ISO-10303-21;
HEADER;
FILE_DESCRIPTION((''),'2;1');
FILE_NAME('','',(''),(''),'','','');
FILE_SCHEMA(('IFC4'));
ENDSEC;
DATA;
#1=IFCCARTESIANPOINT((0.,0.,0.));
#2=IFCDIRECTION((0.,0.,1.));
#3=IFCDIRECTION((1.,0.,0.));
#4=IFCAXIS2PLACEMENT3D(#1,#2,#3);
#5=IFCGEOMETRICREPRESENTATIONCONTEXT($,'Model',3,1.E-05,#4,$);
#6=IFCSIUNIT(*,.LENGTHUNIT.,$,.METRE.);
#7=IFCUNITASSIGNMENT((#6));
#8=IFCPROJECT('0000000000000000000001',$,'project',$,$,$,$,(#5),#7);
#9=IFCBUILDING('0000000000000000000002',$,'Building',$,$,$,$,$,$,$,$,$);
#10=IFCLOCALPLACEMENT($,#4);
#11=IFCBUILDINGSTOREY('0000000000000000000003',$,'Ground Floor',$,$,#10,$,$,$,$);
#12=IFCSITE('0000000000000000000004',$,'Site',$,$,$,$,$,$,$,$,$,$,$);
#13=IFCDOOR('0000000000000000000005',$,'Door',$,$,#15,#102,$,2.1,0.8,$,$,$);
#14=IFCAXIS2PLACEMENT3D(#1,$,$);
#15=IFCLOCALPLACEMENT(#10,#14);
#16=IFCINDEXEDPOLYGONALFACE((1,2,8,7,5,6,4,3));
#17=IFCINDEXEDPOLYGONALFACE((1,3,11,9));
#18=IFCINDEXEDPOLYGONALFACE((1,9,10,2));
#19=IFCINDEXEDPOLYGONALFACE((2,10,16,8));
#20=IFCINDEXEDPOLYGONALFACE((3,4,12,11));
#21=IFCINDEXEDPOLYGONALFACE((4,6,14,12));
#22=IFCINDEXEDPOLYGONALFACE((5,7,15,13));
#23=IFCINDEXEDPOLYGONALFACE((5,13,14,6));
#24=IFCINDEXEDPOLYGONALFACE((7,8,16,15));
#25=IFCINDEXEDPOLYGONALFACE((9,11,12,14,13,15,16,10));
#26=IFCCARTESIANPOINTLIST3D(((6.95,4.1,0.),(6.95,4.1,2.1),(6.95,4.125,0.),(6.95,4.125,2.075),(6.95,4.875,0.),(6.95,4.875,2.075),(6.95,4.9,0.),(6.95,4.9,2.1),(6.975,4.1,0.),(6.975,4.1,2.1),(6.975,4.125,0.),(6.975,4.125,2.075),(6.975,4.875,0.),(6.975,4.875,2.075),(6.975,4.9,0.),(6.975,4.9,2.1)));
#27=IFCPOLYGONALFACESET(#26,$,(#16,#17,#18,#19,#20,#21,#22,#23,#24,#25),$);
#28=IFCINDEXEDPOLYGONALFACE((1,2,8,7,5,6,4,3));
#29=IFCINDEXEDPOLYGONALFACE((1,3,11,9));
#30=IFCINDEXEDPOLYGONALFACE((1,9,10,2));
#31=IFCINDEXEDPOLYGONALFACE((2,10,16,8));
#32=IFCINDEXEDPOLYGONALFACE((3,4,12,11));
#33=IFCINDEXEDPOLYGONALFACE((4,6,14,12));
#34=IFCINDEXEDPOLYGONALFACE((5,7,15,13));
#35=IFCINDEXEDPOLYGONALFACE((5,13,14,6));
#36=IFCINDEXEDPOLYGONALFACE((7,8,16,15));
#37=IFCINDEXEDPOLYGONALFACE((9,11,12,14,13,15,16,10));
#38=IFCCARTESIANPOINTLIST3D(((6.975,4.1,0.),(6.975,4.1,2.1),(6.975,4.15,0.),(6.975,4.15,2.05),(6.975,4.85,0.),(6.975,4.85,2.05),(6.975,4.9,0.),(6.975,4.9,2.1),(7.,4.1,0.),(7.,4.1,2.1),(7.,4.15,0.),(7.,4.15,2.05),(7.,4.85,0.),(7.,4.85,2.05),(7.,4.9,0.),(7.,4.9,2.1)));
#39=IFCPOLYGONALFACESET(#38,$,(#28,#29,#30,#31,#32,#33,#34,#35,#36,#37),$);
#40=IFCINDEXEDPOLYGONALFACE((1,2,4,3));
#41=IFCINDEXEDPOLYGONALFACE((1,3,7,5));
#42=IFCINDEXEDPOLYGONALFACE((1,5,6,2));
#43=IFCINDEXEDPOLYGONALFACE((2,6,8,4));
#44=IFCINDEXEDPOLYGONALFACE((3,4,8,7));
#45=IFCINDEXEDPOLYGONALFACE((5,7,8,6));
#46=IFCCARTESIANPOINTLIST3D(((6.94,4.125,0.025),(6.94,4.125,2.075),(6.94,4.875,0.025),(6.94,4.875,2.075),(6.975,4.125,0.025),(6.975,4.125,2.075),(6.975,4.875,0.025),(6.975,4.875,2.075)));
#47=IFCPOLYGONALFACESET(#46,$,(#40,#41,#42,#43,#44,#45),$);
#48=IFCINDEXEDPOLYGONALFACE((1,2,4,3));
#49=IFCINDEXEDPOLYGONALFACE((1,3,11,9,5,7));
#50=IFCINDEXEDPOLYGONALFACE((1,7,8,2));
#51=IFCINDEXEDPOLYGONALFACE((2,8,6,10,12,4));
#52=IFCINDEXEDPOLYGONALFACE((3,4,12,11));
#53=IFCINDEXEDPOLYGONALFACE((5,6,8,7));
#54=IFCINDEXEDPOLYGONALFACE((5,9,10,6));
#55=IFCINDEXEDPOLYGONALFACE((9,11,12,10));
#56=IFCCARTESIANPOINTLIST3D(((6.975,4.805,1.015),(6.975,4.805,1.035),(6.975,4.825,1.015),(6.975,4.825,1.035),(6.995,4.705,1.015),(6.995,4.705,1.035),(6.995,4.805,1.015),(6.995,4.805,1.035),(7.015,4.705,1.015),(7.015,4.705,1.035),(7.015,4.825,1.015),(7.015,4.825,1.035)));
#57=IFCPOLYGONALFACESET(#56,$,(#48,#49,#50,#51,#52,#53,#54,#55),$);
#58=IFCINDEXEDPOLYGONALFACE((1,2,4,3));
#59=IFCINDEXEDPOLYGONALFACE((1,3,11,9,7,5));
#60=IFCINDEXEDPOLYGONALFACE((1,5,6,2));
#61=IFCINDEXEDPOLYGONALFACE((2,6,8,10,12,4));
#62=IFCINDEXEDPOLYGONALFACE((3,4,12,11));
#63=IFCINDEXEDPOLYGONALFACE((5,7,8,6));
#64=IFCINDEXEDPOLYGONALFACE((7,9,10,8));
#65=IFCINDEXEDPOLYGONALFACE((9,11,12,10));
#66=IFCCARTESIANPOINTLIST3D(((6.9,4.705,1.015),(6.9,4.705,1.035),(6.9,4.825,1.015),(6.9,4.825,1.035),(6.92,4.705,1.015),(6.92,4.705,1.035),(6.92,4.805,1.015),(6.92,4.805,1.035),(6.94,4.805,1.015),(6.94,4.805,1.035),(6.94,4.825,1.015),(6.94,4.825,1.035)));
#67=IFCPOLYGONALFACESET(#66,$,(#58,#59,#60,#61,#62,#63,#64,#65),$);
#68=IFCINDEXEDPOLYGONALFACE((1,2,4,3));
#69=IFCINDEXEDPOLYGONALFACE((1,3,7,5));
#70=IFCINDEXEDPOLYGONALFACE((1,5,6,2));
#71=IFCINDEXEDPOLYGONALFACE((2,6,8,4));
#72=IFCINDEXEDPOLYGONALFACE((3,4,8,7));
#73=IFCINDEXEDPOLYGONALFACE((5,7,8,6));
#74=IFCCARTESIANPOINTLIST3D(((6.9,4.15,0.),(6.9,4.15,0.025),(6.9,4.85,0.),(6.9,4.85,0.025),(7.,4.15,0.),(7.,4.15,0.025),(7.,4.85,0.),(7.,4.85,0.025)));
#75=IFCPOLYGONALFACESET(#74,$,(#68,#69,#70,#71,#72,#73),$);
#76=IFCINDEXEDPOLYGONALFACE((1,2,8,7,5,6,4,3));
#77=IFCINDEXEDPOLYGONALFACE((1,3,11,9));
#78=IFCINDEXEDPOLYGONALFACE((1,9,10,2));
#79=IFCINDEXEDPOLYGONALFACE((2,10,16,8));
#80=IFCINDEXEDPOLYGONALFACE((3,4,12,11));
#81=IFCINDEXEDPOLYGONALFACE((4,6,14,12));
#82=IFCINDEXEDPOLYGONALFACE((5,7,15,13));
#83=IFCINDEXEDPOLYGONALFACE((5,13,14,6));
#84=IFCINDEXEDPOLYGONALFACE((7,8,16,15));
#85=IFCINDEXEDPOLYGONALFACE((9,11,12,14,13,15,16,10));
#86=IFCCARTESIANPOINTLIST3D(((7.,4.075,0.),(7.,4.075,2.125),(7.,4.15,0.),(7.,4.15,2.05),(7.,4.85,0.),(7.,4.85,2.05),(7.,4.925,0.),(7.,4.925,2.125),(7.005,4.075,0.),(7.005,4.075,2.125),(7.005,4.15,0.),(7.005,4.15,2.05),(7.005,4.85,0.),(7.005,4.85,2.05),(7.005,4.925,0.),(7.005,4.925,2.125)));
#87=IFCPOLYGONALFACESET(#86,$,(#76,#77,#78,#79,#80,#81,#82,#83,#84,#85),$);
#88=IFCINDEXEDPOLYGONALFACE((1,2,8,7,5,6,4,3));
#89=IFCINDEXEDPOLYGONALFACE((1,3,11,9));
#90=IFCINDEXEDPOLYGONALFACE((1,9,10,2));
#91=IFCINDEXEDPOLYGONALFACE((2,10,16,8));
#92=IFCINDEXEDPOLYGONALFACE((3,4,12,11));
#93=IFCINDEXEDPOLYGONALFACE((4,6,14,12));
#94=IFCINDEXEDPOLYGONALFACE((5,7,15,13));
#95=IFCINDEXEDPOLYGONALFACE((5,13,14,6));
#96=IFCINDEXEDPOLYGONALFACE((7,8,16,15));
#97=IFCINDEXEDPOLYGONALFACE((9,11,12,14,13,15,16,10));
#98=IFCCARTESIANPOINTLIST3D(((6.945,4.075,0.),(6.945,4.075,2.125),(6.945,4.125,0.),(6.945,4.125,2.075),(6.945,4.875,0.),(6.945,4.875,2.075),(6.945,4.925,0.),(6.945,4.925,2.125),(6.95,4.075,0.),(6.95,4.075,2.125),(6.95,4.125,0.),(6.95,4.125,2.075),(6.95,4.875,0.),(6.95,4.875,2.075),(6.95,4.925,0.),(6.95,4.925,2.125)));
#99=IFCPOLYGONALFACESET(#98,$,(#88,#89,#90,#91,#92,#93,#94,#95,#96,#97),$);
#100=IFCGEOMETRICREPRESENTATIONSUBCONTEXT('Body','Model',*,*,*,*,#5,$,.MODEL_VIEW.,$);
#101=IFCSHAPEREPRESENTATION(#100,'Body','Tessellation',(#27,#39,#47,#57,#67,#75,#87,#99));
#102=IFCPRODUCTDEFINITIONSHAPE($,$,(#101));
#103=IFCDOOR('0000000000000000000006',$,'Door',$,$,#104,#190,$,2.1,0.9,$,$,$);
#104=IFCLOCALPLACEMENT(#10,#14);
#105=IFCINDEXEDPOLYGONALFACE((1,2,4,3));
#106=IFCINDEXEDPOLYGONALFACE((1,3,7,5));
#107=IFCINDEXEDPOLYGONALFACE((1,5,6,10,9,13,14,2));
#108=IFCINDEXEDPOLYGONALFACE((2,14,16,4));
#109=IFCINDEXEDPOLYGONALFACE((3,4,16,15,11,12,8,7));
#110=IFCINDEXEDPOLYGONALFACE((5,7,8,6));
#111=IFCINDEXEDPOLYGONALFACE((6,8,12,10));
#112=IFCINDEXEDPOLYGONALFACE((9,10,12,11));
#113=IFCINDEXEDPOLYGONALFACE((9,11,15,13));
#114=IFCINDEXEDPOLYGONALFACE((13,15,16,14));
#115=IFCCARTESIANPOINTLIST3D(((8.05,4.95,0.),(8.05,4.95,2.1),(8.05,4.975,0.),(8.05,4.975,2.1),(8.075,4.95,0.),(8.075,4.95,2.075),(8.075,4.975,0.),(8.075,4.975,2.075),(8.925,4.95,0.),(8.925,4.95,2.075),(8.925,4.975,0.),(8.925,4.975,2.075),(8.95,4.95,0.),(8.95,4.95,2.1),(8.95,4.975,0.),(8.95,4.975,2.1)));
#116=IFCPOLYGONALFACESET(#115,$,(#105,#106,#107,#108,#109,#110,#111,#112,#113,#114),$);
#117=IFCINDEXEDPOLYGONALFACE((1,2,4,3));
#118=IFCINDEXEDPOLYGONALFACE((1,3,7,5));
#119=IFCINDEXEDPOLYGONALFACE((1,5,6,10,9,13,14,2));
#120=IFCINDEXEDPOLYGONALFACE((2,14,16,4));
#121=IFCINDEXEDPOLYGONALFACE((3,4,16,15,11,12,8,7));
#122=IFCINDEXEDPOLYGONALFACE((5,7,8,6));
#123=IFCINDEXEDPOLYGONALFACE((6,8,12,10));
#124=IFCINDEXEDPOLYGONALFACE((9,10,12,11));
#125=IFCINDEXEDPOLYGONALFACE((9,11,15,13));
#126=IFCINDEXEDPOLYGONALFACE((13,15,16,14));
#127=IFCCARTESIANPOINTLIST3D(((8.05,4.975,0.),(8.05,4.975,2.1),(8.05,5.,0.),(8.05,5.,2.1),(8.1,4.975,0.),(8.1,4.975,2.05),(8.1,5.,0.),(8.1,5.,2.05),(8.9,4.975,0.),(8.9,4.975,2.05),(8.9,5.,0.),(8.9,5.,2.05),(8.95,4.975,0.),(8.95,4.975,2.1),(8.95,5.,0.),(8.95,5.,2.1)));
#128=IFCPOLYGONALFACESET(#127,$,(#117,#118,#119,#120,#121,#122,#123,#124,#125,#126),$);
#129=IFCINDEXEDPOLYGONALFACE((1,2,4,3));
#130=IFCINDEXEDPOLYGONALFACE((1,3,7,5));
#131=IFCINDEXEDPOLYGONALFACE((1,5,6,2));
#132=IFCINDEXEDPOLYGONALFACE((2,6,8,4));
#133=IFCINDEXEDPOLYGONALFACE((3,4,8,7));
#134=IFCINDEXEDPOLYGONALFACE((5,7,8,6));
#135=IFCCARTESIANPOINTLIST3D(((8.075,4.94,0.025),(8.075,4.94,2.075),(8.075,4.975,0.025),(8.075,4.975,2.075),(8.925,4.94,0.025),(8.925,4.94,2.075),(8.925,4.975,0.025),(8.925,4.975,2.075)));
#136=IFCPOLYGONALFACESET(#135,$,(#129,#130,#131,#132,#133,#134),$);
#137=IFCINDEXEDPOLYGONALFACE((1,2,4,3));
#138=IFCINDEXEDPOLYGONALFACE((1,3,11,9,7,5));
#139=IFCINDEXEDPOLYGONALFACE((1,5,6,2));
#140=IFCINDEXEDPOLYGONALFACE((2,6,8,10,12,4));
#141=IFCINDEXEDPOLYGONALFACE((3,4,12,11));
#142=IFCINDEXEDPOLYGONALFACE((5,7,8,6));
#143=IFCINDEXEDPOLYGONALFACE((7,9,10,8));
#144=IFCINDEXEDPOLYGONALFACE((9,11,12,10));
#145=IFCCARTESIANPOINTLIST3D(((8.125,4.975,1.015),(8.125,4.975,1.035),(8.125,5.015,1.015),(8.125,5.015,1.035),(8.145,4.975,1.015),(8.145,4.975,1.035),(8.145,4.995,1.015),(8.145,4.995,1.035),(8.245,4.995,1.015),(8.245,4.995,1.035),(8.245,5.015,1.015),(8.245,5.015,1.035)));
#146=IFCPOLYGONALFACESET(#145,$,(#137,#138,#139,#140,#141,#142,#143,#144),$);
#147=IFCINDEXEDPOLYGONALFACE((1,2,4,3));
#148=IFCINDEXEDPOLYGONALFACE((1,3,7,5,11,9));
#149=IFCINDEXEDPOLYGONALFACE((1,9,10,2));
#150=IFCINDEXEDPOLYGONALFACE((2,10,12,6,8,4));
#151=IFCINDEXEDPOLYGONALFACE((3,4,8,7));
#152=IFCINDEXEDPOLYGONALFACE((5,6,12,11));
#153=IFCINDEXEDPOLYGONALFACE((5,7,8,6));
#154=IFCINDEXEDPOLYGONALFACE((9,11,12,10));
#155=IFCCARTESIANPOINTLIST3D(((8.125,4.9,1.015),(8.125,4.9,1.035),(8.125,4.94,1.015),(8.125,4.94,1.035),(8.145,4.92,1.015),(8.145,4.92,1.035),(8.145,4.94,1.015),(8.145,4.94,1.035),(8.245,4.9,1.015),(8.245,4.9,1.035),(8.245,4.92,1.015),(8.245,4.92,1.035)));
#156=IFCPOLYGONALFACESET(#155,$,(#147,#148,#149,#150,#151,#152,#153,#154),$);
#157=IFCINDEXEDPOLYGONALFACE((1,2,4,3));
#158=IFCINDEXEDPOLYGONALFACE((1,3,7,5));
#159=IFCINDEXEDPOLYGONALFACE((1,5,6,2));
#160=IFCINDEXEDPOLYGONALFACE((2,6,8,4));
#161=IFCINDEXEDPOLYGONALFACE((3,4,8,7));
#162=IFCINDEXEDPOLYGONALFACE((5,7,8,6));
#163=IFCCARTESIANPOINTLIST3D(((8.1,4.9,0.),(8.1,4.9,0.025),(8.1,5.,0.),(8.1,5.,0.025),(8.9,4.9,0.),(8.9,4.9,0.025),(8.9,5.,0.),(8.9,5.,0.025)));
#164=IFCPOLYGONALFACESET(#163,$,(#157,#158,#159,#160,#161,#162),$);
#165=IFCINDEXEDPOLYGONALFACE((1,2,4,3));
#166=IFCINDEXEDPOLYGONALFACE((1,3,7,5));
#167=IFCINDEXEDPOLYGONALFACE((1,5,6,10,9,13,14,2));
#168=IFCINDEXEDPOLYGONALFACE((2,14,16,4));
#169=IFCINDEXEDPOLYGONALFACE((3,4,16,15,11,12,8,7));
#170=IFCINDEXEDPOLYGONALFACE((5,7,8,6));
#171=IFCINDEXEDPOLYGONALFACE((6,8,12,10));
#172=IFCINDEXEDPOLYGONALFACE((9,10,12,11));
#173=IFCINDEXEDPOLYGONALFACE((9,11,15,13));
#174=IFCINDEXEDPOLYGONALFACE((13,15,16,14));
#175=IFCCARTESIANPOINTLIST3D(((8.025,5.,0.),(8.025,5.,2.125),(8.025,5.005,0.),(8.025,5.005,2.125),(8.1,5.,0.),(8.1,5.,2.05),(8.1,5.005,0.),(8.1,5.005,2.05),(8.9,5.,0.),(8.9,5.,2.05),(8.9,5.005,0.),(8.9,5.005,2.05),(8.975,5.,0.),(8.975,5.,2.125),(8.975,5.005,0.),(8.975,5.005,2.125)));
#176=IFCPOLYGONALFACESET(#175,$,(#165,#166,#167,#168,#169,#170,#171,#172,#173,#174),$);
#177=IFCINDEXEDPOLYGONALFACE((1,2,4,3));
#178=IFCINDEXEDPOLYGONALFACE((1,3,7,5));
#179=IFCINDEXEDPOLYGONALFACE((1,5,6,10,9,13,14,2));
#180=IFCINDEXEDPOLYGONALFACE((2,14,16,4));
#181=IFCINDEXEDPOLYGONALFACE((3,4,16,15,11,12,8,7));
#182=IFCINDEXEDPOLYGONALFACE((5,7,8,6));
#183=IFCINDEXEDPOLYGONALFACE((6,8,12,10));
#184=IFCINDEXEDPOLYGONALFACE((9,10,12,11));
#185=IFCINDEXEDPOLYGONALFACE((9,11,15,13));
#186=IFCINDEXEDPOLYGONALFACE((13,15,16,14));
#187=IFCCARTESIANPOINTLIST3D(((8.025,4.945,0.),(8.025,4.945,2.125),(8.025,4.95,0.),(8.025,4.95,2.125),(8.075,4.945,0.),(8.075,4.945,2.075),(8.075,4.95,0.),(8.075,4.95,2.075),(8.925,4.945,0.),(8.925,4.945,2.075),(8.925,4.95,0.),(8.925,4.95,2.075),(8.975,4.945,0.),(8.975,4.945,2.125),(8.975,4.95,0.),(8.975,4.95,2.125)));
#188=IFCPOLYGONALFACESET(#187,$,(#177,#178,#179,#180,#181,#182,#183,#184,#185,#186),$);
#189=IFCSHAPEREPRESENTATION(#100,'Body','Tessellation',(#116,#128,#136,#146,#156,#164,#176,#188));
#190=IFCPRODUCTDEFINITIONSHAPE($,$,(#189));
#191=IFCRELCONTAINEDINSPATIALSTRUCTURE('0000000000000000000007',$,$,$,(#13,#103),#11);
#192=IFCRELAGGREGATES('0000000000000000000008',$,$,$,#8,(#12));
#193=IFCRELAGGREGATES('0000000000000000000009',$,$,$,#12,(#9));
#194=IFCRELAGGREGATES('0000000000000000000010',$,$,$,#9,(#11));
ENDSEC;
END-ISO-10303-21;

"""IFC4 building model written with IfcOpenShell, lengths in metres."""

from ifc_helpers import new_model, si_unit, frame, origin_with_axes, place, context, subcontext, project, spatial, line, indexed_curve, outline, extrude, element, save


model = new_model("IFC4")

# Units and contexts
model_context = context("Model", 3, precision=1e-05, world=origin_with_axes())
body_context = subcontext(model_context, "Body", "Model", "MODEL_VIEW")
ifc_project = project(units=[si_unit("LENGTHUNIT", "METRE")], contexts=[model_context])

# Site, building, storey
site = spatial("IfcSite", under=ifc_project, Name="Site")
building = spatial("IfcBuilding", under=site, Name="Building")
storey_placement = place(None, origin_with_axes())
storey = spatial("IfcBuildingStorey", under=building, at=storey_placement, Name="Ground Floor")

# Doors
door_1_placement = place(storey_placement, frame((7.0, 4.1, 0.0), z_axis=(0.0, 0.0, 1.0), x_axis=(0.0, 1.0, 0.0)))
element("IfcDoor", 1, at=door_1_placement, inside=storey, Name="Door", OverallHeight=2.1, OverallWidth=0.8, context=body_context, shape_type="SweptSolid", body=[
    extrude(outline(indexed_curve([(0.0, 0.0), (0.0, 2.1), (0.8, 2.1), (0.8, 0.0), (0.775, 0.0), (0.775, 2.075), (0.025, 2.075), (0.025, 0.0)], segments=[line(1, 2, 3, 4, 5, 6, 7, 8, 1)])), frame((0.0, 0.025, 0.0), z_axis=(0.0, -1.0, 0.0), x_axis=(1.0, 0.0, 0.0)), (0.0, 0.0, -1.0), 0.025),
    extrude(outline(indexed_curve([(0.0, 0.0), (0.0, 2.1), (0.8, 2.1), (0.8, 0.0), (0.75, 0.0), (0.75, 2.05), (0.05, 2.05), (0.05, 0.0)], segments=[line(1, 2, 3, 4, 5, 6, 7, 8, 1)])), frame((0.0, 0.0, 0.0), z_axis=(0.0, -1.0, 0.0), x_axis=(1.0, 0.0, 0.0)), (0.0, 0.0, -1.0), 0.025),
    extrude(outline(indexed_curve([(0.0, 0.0), (0.75, 0.0), (0.75, 0.035), (0.0, 0.035)], segments=[line(1, 2, 3, 4, 1)])), frame((0.025, 0.025, 0.025), z_axis=(0.0, 0.0, 1.0), x_axis=(1.0, 0.0, 0.0)), (0.0, 0.0, 1.0), 2.05),
    extrude(outline(indexed_curve([(0.0, 0.0), (0.0, -0.04), (-0.12, -0.04), (-0.12, -0.02), (-0.02, -0.02), (-0.02, 0.0)], segments=[line(1, 2, 3, 4, 5, 6, 1)])), frame((0.725, 0.025, 1.015), z_axis=(0.0, 0.0, 1.0), x_axis=(1.0, 0.0, 0.0)), (0.0, 0.0, 1.0), 0.02),
    extrude(outline(indexed_curve([(0.0, 0.0), (0.0, 0.04), (-0.12, 0.04), (-0.12, 0.02), (-0.02, 0.02), (-0.02, 0.0)], segments=[line(1, 2, 3, 4, 5, 6, 1)])), frame((0.725, 0.06, 1.015), z_axis=(0.0, 0.0, 1.0), x_axis=(1.0, 0.0, 0.0)), (0.0, 0.0, 1.0), 0.02),
    extrude(outline(indexed_curve([(0.0, 0.0), (0.7, 0.0), (0.7, 0.1), (0.0, 0.1)], segments=[line(1, 2, 3, 4, 1)])), frame((0.05, 0.0, 0.0), z_axis=(0.0, 0.0, 1.0), x_axis=(1.0, 0.0, 0.0)), (0.0, 0.0, 1.0), 0.025),
    extrude(outline(indexed_curve([(0.0, 0.0), (0.0, 2.125), (0.85, 2.125), (0.85, 0.0), (0.775, 0.0), (0.775, 2.05), (0.075, 2.05), (0.075, 0.0)], segments=[line(1, 2, 3, 4, 5, 6, 7, 8, 1)])), frame((-0.025, -0.005, 0.0), z_axis=(0.0, -1.0, 0.0), x_axis=(1.0, 0.0, 0.0)), (0.0, 0.0, -1.0), 0.005),
    extrude(outline(indexed_curve([(0.0, 0.0), (0.0, 2.125), (0.85, 2.125), (0.85, 0.0), (0.8, 0.0), (0.8, 2.075), (0.05, 2.075), (0.05, 0.0)], segments=[line(1, 2, 3, 4, 5, 6, 7, 8, 1)])), frame((-0.025, 0.05, 0.0), z_axis=(0.0, -1.0, 0.0), x_axis=(1.0, 0.0, 0.0)), (0.0, 0.0, -1.0), 0.005),
])
door_2_placement = place(storey_placement, frame((8.95, 5.0, 0.0), z_axis=(0.0, 0.0, 1.0), x_axis=(-1.0, 0.0, 0.0)))
element("IfcDoor", 2, at=door_2_placement, inside=storey, Name="Door", OverallHeight=2.1, OverallWidth=0.9, context=body_context, shape_type="SweptSolid", body=[
    extrude(outline(indexed_curve([(0.0, 0.0), (0.0, 2.1), (0.9, 2.1), (0.9, 0.0), (0.875, 0.0), (0.875, 2.075), (0.025, 2.075), (0.025, 0.0)], segments=[line(1, 2, 3, 4, 5, 6, 7, 8, 1)])), frame((0.0, 0.025, 0.0), z_axis=(0.0, -1.0, 0.0), x_axis=(1.0, 0.0, 0.0)), (0.0, 0.0, -1.0), 0.025),
    extrude(outline(indexed_curve([(0.0, 0.0), (0.0, 2.1), (0.9, 2.1), (0.9, 0.0), (0.85, 0.0), (0.85, 2.05), (0.05, 2.05), (0.05, 0.0)], segments=[line(1, 2, 3, 4, 5, 6, 7, 8, 1)])), frame((0.0, 0.0, 0.0), z_axis=(0.0, -1.0, 0.0), x_axis=(1.0, 0.0, 0.0)), (0.0, 0.0, -1.0), 0.025),
    extrude(outline(indexed_curve([(0.0, 0.0), (0.85, 0.0), (0.85, 0.035), (0.0, 0.035)], segments=[line(1, 2, 3, 4, 1)])), frame((0.025, 0.025, 0.025), z_axis=(0.0, 0.0, 1.0), x_axis=(1.0, 0.0, 0.0)), (0.0, 0.0, 1.0), 2.05),
    extrude(outline(indexed_curve([(0.0, 0.0), (0.0, -0.04), (-0.12, -0.04), (-0.12, -0.02), (-0.02, -0.02), (-0.02, 0.0)], segments=[line(1, 2, 3, 4, 5, 6, 1)])), frame((0.825, 0.025, 1.015), z_axis=(0.0, 0.0, 1.0), x_axis=(1.0, 0.0, 0.0)), (0.0, 0.0, 1.0), 0.02),
    extrude(outline(indexed_curve([(0.0, 0.0), (0.0, 0.04), (-0.12, 0.04), (-0.12, 0.02), (-0.02, 0.02), (-0.02, 0.0)], segments=[line(1, 2, 3, 4, 5, 6, 1)])), frame((0.825, 0.06, 1.015), z_axis=(0.0, 0.0, 1.0), x_axis=(1.0, 0.0, 0.0)), (0.0, 0.0, 1.0), 0.02),
    extrude(outline(indexed_curve([(0.0, 0.0), (0.8, 0.0), (0.8, 0.1), (0.0, 0.1)], segments=[line(1, 2, 3, 4, 1)])), frame((0.05, 0.0, 0.0), z_axis=(0.0, 0.0, 1.0), x_axis=(1.0, 0.0, 0.0)), (0.0, 0.0, 1.0), 0.025),
    extrude(outline(indexed_curve([(0.0, 0.0), (0.0, 2.125), (0.95, 2.125), (0.95, 0.0), (0.875, 0.0), (0.875, 2.05), (0.075, 2.05), (0.075, 0.0)], segments=[line(1, 2, 3, 4, 5, 6, 7, 8, 1)])), frame((-0.025, -0.005, 0.0), z_axis=(0.0, -1.0, 0.0), x_axis=(1.0, 0.0, 0.0)), (0.0, 0.0, -1.0), 0.005),
    extrude(outline(indexed_curve([(0.0, 0.0), (0.0, 2.125), (0.95, 2.125), (0.95, 0.0), (0.9, 0.0), (0.9, 2.075), (0.05, 2.075), (0.05, 0.0)], segments=[line(1, 2, 3, 4, 5, 6, 7, 8, 1)])), frame((-0.025, 0.05, 0.0), z_axis=(0.0, -1.0, 0.0), x_axis=(1.0, 0.0, 0.0)), (0.0, 0.0, -1.0), 0.005),
])

save(model, "model.ifc")
